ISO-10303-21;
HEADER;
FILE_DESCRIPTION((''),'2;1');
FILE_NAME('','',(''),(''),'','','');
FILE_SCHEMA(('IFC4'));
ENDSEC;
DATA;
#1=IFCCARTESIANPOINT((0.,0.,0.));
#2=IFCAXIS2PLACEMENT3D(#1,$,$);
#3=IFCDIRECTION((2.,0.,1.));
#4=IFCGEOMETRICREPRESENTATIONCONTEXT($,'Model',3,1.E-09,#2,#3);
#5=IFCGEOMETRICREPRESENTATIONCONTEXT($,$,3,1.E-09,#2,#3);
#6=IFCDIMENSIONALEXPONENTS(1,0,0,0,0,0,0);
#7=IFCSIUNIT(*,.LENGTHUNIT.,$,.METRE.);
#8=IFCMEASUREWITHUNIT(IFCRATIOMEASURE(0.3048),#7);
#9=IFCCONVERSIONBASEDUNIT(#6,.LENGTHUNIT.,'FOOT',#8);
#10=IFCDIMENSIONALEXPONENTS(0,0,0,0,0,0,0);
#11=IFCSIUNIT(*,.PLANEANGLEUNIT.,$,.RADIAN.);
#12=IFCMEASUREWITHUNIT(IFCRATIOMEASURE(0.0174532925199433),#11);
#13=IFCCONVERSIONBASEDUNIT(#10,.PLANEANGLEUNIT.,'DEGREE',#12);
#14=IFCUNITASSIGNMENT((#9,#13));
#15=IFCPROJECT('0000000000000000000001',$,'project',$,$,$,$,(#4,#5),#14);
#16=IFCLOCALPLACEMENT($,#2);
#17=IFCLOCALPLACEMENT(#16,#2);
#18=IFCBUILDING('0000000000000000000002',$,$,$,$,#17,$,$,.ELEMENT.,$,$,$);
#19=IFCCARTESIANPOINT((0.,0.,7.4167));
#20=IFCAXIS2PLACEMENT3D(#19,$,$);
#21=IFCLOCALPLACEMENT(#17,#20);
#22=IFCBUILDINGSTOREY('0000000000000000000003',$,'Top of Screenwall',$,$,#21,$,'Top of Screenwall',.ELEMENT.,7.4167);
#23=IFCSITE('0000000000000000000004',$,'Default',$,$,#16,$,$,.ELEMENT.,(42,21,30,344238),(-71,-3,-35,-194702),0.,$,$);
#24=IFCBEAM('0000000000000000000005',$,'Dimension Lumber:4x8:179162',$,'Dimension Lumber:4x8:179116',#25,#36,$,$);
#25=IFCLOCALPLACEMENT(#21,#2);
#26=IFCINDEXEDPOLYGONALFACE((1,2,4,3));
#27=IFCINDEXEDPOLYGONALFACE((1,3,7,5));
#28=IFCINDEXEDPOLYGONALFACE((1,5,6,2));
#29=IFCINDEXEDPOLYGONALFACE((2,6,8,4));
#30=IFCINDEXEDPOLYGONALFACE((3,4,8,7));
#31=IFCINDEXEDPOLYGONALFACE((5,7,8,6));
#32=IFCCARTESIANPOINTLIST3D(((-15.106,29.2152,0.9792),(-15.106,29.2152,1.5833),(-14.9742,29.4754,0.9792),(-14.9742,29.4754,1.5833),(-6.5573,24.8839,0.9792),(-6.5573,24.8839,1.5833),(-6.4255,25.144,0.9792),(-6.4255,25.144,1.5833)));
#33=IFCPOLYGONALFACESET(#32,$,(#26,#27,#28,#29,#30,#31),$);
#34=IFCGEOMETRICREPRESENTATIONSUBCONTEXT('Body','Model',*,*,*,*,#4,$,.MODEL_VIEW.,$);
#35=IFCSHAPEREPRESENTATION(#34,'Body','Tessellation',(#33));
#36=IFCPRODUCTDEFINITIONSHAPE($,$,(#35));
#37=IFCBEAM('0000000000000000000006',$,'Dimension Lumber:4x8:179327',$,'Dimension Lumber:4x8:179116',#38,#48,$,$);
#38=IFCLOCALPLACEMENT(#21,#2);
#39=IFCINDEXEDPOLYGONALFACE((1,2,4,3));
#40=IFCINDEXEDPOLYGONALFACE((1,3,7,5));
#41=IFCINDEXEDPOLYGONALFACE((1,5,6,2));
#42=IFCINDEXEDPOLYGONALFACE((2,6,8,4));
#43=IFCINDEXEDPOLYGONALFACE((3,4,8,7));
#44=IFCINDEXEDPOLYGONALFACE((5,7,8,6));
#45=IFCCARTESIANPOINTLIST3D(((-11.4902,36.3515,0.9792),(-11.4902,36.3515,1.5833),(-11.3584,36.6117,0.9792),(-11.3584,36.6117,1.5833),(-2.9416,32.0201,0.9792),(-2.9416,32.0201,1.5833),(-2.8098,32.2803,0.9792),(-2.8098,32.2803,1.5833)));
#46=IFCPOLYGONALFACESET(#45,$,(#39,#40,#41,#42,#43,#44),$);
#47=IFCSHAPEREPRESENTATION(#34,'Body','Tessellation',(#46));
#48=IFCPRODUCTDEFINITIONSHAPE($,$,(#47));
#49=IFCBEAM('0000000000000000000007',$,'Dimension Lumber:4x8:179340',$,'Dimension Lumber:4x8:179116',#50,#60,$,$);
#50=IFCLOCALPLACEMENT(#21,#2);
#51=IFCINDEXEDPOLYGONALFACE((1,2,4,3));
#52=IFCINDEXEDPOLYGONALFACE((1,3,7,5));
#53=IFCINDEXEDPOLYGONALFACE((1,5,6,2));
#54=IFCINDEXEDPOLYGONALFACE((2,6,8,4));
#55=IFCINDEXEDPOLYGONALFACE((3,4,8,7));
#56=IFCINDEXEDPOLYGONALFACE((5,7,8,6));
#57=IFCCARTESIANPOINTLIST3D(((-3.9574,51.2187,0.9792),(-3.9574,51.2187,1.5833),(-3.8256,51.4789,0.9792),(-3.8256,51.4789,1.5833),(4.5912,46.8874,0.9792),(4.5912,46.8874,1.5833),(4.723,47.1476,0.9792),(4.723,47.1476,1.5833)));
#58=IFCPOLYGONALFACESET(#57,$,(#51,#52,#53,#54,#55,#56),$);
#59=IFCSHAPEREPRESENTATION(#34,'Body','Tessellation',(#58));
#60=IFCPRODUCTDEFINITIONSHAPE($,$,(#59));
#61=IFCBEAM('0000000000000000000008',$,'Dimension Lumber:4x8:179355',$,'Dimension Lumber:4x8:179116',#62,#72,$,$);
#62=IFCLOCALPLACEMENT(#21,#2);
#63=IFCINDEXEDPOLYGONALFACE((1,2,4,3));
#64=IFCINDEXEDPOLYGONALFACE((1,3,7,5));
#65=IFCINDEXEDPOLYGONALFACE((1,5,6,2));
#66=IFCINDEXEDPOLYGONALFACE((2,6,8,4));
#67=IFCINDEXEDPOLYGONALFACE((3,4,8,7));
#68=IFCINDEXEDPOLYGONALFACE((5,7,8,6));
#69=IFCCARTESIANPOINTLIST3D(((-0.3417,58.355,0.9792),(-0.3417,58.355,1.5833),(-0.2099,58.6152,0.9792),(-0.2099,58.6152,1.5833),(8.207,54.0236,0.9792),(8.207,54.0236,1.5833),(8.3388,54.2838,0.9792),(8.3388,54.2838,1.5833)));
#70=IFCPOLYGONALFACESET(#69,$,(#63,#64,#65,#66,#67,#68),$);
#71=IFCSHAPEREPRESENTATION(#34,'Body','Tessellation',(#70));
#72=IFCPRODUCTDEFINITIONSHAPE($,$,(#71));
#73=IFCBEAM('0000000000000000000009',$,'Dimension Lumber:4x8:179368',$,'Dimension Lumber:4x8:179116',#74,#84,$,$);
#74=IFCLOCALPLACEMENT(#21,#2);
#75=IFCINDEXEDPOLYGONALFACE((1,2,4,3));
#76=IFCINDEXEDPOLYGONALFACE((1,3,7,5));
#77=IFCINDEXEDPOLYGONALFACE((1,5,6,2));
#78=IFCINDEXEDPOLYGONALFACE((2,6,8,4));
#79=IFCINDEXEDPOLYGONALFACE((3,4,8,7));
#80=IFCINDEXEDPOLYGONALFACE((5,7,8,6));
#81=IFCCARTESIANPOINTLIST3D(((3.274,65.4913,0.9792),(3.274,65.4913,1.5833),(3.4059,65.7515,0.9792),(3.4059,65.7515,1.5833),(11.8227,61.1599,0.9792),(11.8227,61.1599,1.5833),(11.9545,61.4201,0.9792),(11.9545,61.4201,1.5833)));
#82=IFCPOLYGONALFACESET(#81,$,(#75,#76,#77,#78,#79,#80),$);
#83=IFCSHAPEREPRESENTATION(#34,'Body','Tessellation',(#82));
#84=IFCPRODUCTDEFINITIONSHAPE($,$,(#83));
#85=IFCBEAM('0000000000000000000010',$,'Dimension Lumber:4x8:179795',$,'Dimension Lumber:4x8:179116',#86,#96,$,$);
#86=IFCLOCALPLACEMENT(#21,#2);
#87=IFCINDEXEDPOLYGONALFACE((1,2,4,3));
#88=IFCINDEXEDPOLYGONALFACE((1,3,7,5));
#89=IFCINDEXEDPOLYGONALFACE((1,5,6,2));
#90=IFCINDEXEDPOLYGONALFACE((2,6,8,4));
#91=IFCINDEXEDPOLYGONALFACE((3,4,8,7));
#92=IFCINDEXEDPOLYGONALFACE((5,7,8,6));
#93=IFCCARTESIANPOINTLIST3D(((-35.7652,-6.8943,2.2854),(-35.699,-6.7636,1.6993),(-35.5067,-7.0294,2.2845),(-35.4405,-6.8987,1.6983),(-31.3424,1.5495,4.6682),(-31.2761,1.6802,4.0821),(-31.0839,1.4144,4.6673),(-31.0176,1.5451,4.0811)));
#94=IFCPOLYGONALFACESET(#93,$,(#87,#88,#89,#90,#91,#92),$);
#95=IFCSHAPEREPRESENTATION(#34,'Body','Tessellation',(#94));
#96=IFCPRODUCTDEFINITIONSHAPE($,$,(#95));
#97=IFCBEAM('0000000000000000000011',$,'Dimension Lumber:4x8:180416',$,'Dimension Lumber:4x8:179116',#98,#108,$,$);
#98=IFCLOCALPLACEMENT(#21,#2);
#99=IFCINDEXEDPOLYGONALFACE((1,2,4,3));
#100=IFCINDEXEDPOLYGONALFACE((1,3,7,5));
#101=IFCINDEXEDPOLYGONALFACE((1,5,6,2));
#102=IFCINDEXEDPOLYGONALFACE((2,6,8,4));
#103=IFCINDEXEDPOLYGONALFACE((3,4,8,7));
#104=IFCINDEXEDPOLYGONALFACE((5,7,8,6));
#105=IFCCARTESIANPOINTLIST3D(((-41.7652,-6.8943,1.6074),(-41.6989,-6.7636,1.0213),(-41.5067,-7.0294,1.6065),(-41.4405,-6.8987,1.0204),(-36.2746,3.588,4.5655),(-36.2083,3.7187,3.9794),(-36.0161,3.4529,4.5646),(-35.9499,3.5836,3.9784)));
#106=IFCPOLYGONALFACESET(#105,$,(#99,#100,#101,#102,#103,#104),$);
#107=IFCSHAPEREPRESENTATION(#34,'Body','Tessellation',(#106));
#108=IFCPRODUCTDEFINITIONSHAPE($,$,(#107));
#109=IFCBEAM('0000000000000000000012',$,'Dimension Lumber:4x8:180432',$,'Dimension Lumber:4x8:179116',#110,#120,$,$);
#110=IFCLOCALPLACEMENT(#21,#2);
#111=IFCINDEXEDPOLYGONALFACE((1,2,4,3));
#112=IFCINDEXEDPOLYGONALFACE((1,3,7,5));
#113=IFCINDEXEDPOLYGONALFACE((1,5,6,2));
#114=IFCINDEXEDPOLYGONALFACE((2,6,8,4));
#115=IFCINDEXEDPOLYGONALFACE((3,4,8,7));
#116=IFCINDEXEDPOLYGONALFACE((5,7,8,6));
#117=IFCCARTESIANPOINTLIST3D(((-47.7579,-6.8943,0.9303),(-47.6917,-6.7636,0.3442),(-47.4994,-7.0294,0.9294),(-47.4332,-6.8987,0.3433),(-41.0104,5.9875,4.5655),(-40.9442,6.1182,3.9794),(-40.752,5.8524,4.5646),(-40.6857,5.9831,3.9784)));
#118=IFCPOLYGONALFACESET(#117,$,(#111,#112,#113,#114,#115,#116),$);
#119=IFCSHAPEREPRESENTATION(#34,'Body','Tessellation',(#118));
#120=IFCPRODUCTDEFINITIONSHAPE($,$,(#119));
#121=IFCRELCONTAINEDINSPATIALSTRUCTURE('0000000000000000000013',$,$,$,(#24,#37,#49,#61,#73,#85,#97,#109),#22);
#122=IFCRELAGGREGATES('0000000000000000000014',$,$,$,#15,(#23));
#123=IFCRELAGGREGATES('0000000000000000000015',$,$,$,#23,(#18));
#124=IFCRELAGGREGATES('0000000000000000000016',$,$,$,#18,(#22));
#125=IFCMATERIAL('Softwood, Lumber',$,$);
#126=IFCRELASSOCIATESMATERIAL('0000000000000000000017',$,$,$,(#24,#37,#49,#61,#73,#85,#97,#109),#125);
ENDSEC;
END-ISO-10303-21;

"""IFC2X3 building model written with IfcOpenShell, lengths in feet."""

from ifc_helpers import new_model, entity, si_unit, converted_unit, direction, frame, frame_2d, origin, place, context, subcontext, project, spatial, rectangle, extrude, material, element, save


model = new_model("IFC2X3")

# Units and contexts
model_context = context("Model", 3, precision=1e-09, world=origin(), true_north=direction((2.0, 0.0, 1.0)))
context_of_model = context(None, 3, precision=1e-09, world=origin(), true_north=direction((2.0, 0.0, 1.0)))
body_context = subcontext(model_context, "Body", "Model", "MODEL_VIEW")
ifc_project = project(units=[converted_unit("LENGTHUNIT", "FOOT", entity("IfcRatioMeasure", 0.3048), si_unit("LENGTHUNIT", "METRE"), dimensions=[1, 0, 0, 0, 0, 0, 0]), converted_unit("PLANEANGLEUNIT", "DEGREE", entity("IfcRatioMeasure", 0.0174532925199433), si_unit("PLANEANGLEUNIT", "RADIAN"), dimensions=[0, 0, 0, 0, 0, 0, 0])], contexts=[model_context, context_of_model])

# Site, building, storey
site_placement = place(None, origin())
site = spatial("IfcSite", under=ifc_project, at=site_placement, Name="Default", CompositionType="ELEMENT", RefLatitude=(42, 21, 30, 344238), RefLongitude=(-71, -3, -35, -194702), RefElevation=0.0)
building_placement = place(site_placement, origin())
building = spatial("IfcBuilding", under=site, at=building_placement, CompositionType="ELEMENT")
storey_placement = place(building_placement, frame((0.0, 0.0, 7.4167)))
storey = spatial("IfcBuildingStorey", under=building, at=storey_placement, Name="Top of Screenwall", LongName="Top of Screenwall", CompositionType="ELEMENT", Elevation=7.4167)

# Beams
ifc_material = material(Name="Softwood, Lumber")
beam_1_placement = place(storey_placement, frame((-15.0401, 29.3453, 1.5833), z_axis=(0.0, 0.0, 1.0), x_axis=(0.892034, -0.451968, 0.0)))
element("IfcBeam", 1, at=beam_1_placement, inside=storey, material=ifc_material, Name="Dimension Lumber:4x8:179162", ObjectType="Dimension Lumber:4x8:179116", context=body_context, shape_type="SweptSolid", body=[
    extrude(rectangle(XDim=0.6042, YDim=0.2917, at=frame_2d((0.0, 0.0), x_axis=(1.0, 0.0))), frame((0.0, 0.0, -0.3021), z_axis=(1.0, 0.0, 0.0), x_axis=(0.0, 0.0, -1.0)), (0.0, 0.0, 1.0), 9.5833),
])
beam_2_placement = place(storey_placement, frame((-11.4243, 36.4816, 1.5833), z_axis=(0.0, 0.0, 1.0), x_axis=(0.892034, -0.451968, 0.0)))
element("IfcBeam", 2, at=beam_2_placement, inside=storey, material=ifc_material, Name="Dimension Lumber:4x8:179327", ObjectType="Dimension Lumber:4x8:179116", context=body_context, shape_type="SweptSolid", body=[
    extrude(rectangle(XDim=0.6042, YDim=0.2917, at=frame_2d((0.0, 0.0), x_axis=(1.0, 0.0))), frame((0.0, 0.0, -0.3021), z_axis=(1.0, 0.0, 0.0), x_axis=(0.0, 0.0, -1.0)), (0.0, 0.0, 1.0), 9.5833),
])
beam_3_placement = place(storey_placement, frame((-3.8915, 51.3488, 1.5833), z_axis=(0.0, 0.0, 1.0), x_axis=(0.892034, -0.451968, 0.0)))
element("IfcBeam", 3, at=beam_3_placement, inside=storey, material=ifc_material, Name="Dimension Lumber:4x8:179340", ObjectType="Dimension Lumber:4x8:179116", context=body_context, shape_type="SweptSolid", body=[
    extrude(rectangle(XDim=0.6042, YDim=0.2917, at=frame_2d((0.0, 0.0), x_axis=(1.0, 0.0))), frame((0.0, 0.0, -0.3021), z_axis=(1.0, 0.0, 0.0), x_axis=(0.0, 0.0, -1.0)), (0.0, 0.0, 1.0), 9.5833),
])
beam_4_placement = place(storey_placement, frame((-0.2758, 58.4851, 1.5833), z_axis=(0.0, 0.0, 1.0), x_axis=(0.892034, -0.451968, 0.0)))
element("IfcBeam", 4, at=beam_4_placement, inside=storey, material=ifc_material, Name="Dimension Lumber:4x8:179355", ObjectType="Dimension Lumber:4x8:179116", context=body_context, shape_type="SweptSolid", body=[
    extrude(rectangle(XDim=0.6042, YDim=0.2917, at=frame_2d((0.0, 0.0), x_axis=(1.0, 0.0))), frame((0.0, 0.0, -0.3021), z_axis=(1.0, 0.0, 0.0), x_axis=(0.0, 0.0, -1.0)), (0.0, 0.0, 1.0), 9.5833),
])
beam_5_placement = place(storey_placement, frame((3.34, 65.6214, 1.5833), z_axis=(0.0, 0.0, 1.0), x_axis=(0.892034, -0.451968, 0.0)))
element("IfcBeam", 5, at=beam_5_placement, inside=storey, material=ifc_material, Name="Dimension Lumber:4x8:179368", ObjectType="Dimension Lumber:4x8:179116", context=body_context, shape_type="SweptSolid", body=[
    extrude(rectangle(XDim=0.6042, YDim=0.2917, at=frame_2d((0.0, 0.0), x_axis=(1.0, 0.0))), frame((0.0, 0.0, -0.3021), z_axis=(1.0, 0.0, 0.0), x_axis=(0.0, 0.0, -1.0)), (0.0, 0.0, 1.0), 9.5833),
])
beam_6_placement = place(storey_placement, frame((-31.2131, 1.4819, 4.6677), z_axis=(-0.112527, -0.214828, 0.970148), x_axis=(-0.450148, -0.859391, -0.242515)))
element("IfcBeam", 6, at=beam_6_placement, inside=storey, material=ifc_material, Name="Dimension Lumber:4x8:179795", ObjectType="Dimension Lumber:4x8:179116", context=body_context, shape_type="SweptSolid", body=[
    extrude(rectangle(XDim=0.6042, YDim=0.2917, at=frame_2d((0.0, 0.0), x_axis=(0.0, 1.0))), frame((0.0, -0.001, -0.3021), z_axis=(1.0, 0.0, 0.0), x_axis=(0.0, -0.999995, 0.003283)), (0.0, 0.0, 1.0), 9.8253),
])
beam_7_placement = place(storey_placement, frame((-36.1453, 3.5204, 4.565), z_axis=(-0.112527, -0.214828, 0.970148), x_axis=(-0.450148, -0.859391, -0.242515)))
element("IfcBeam", 7, at=beam_7_placement, inside=storey, material=ifc_material, Name="Dimension Lumber:4x8:180416", ObjectType="Dimension Lumber:4x8:179116", context=body_context, shape_type="SweptSolid", body=[
    extrude(rectangle(XDim=0.6042, YDim=0.2917, at=frame_2d((0.0, 0.0), x_axis=(0.0, 1.0))), frame((0.0, -0.001, -0.3021), z_axis=(1.0, 0.0, 0.0), x_axis=(0.0, -0.999995, 0.003283)), (0.0, 0.0, 1.0), 12.1973),
])
beam_8_placement = place(storey_placement, frame((-40.8812, 5.92, 4.565), z_axis=(-0.112527, -0.214828, 0.970148), x_axis=(-0.450148, -0.859391, -0.242515)))
element("IfcBeam", 8, at=beam_8_placement, inside=storey, material=ifc_material, Name="Dimension Lumber:4x8:180432", ObjectType="Dimension Lumber:4x8:179116", context=body_context, shape_type="SweptSolid", body=[
    extrude(rectangle(XDim=0.6042, YDim=0.2917, at=frame_2d((0.0, 0.0), x_axis=(0.0, 1.0))), frame((0.0, -0.001, -0.3021), z_axis=(1.0, 0.0, 0.0), x_axis=(0.0, -0.999995, 0.003283)), (0.0, 0.0, 1.0), 14.9894),
])

save(model, "model.ifc")
